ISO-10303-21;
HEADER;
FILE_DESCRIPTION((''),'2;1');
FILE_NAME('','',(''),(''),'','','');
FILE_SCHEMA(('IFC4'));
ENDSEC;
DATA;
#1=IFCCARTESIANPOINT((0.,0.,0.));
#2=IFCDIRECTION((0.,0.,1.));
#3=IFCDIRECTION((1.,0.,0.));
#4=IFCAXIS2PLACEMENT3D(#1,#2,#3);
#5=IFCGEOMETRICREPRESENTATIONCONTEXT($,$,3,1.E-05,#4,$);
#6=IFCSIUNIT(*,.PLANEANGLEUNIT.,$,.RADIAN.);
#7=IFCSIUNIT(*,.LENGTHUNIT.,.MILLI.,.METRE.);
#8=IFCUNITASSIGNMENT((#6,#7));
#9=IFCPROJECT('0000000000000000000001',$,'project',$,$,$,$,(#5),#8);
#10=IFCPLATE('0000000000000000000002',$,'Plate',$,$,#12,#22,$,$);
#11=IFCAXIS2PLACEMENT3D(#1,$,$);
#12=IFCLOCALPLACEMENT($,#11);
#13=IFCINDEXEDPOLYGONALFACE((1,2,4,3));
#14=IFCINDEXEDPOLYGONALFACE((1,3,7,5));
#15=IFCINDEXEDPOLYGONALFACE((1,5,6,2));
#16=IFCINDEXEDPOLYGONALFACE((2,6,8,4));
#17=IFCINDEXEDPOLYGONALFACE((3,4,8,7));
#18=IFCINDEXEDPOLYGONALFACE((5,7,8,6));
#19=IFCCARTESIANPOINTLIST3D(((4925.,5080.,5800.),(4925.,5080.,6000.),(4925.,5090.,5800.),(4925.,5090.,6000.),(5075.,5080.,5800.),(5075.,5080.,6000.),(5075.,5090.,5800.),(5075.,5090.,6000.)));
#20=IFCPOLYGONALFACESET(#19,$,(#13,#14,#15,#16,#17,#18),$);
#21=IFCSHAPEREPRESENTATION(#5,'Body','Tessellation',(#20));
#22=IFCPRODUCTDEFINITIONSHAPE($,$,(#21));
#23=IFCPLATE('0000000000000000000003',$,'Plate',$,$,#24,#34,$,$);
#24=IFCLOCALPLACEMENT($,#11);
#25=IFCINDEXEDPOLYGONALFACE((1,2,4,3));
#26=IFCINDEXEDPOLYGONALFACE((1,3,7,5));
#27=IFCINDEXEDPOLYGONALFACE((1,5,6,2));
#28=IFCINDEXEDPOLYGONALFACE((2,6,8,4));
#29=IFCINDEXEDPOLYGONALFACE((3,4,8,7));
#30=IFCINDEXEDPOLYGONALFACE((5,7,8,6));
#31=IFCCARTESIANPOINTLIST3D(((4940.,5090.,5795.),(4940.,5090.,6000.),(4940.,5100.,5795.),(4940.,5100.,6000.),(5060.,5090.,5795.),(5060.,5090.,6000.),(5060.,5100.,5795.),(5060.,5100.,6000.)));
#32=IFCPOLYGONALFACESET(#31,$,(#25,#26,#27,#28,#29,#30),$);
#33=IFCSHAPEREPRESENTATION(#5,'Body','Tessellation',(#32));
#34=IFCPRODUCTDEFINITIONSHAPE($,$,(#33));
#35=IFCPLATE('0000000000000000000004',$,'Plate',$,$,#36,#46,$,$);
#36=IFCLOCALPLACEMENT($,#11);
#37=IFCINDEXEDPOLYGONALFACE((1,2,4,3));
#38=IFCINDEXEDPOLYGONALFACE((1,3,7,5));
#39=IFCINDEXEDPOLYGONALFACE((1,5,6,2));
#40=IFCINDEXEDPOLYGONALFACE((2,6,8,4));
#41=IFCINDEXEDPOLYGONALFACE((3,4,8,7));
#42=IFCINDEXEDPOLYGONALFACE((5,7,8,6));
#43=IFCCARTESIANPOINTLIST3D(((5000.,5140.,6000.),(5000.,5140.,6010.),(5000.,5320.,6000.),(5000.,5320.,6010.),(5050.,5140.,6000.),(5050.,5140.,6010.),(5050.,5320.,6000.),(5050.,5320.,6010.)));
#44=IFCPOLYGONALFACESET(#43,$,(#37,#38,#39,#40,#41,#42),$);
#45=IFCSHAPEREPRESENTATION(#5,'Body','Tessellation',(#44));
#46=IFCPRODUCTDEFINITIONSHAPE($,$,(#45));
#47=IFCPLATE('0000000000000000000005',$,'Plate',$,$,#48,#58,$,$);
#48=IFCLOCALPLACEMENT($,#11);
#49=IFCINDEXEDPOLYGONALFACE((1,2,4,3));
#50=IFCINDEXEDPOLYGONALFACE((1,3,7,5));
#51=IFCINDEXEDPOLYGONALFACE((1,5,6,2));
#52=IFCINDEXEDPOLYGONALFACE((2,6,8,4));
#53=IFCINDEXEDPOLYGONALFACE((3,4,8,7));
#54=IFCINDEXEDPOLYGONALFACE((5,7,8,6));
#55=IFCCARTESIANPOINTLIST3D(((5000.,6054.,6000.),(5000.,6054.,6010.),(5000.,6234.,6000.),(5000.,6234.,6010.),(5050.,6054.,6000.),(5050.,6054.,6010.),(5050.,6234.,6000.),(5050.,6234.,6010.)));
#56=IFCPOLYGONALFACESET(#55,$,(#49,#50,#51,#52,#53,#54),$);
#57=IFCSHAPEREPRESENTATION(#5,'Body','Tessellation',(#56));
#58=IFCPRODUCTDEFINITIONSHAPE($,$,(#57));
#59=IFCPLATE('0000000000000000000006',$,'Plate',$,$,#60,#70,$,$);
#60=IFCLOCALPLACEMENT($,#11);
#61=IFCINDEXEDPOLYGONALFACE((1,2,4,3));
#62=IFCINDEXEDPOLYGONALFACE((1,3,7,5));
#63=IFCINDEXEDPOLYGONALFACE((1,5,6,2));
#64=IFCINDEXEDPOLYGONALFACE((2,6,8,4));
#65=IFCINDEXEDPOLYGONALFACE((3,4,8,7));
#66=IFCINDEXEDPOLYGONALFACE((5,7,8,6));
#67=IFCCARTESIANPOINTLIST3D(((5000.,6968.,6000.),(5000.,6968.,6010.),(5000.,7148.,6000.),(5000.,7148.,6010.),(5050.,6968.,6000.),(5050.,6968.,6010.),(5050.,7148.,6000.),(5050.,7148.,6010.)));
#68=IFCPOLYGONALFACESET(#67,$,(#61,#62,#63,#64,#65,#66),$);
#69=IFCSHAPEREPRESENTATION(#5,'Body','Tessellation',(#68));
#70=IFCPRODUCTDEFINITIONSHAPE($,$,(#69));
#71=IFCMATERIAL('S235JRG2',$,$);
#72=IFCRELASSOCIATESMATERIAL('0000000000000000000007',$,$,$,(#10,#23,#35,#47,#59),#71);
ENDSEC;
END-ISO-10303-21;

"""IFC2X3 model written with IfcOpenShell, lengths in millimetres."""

from ifc_helpers import new_model, si_unit, frame, origin_with_axes, place, context, project, polyline, outline, extrude, material, element, save


model = new_model("IFC2X3")

# Units and contexts
context_of_model = context(None, 3, precision=1e-05, world=origin_with_axes())
ifc_project = project(units=[si_unit("PLANEANGLEUNIT", "RADIAN"), si_unit("LENGTHUNIT", "METRE", prefix="MILLI")], contexts=[context_of_model])

# Shared definitions
ifc_material = material(Name="S235JRG2")

# Plates
placement_1 = place(None, origin_with_axes())
plate_1_placement = place(placement_1, frame((4925.0, 5080.0, 6000.0), z_axis=(0.0, 0.0, -1.0), x_axis=(0.0, 1.0, 0.0)))
element("IfcPlate", 1, at=plate_1_placement, material=ifc_material, Name="Plate", context=context_of_model, shape_type="SweptSolid", body=[
    extrude(outline(polyline([(0.0, 0.0), (150.0, 0.0), (150.0, 200.0), (0.0, 200.0), (0.0, 0.0)])), frame((0.0, 0.0, 0.0), z_axis=(1.0, 0.0, 0.0), x_axis=(0.0, 1.0, 0.0)), (0.0, 0.0, 1.0), 10.0),
])
placement_2 = place(None, origin_with_axes())
plate_2_placement = place(placement_2, frame((5060.0, 5100.0, 6000.0), z_axis=(0.0, 0.0, -1.0), x_axis=(0.0, -1.0, 0.0)))
element("IfcPlate", 2, at=plate_2_placement, material=ifc_material, Name="Plate", context=context_of_model, shape_type="SweptSolid", body=[
    extrude(outline(polyline([(0.0, 0.0), (120.0, 0.0), (120.0, 205.0), (0.0, 205.0), (0.0, 0.0)])), frame((0.0, 0.0, 0.0), z_axis=(1.0, 0.0, 0.0), x_axis=(0.0, 1.0, 0.0)), (0.0, 0.0, 1.0), 10.0),
])
placement_3 = place(None, origin_with_axes())
plate_3_placement = place(placement_3, frame((5000.0, 5140.0, 6010.0), z_axis=(1.0, 0.0, 0.0), x_axis=(0.0, 0.0, -1.0)))
element("IfcPlate", 3, at=plate_3_placement, material=ifc_material, Name="Plate", context=context_of_model, shape_type="SweptSolid", body=[
    extrude(outline(polyline([(0.0, 0.0), (180.0, 0.0), (180.0, 50.0), (0.0, 50.0), (0.0, 0.0)])), frame((0.0, 0.0, 0.0), z_axis=(1.0, 0.0, 0.0), x_axis=(0.0, 1.0, 0.0)), (0.0, 0.0, 1.0), 10.0),
])
placement_4 = place(None, origin_with_axes())
plate_4_placement = place(placement_4, frame((5000.0, 6054.0, 6010.0), z_axis=(1.0, 0.0, 0.0), x_axis=(0.0, 0.0, -1.0)))
element("IfcPlate", 4, at=plate_4_placement, material=ifc_material, Name="Plate", context=context_of_model, shape_type="SweptSolid", body=[
    extrude(outline(polyline([(0.0, 0.0), (180.0, 0.0), (180.0, 50.0), (0.0, 50.0), (0.0, 0.0)])), frame((0.0, 0.0, 0.0), z_axis=(1.0, 0.0, 0.0), x_axis=(0.0, 1.0, 0.0)), (0.0, 0.0, 1.0), 10.0),
])
placement_5 = place(None, origin_with_axes())
plate_5_placement = place(placement_5, frame((5000.0, 6968.0, 6010.0), z_axis=(1.0, 0.0, 0.0), x_axis=(0.0, 0.0, -1.0)))
element("IfcPlate", 5, at=plate_5_placement, material=ifc_material, Name="Plate", context=context_of_model, shape_type="SweptSolid", body=[
    extrude(outline(polyline([(0.0, 0.0), (180.0, 0.0), (180.0, 50.0), (0.0, 50.0), (0.0, 0.0)])), frame((0.0, 0.0, 0.0), z_axis=(1.0, 0.0, 0.0), x_axis=(0.0, 1.0, 0.0)), (0.0, 0.0, 1.0), 10.0),
])

save(model, "model.ifc")
